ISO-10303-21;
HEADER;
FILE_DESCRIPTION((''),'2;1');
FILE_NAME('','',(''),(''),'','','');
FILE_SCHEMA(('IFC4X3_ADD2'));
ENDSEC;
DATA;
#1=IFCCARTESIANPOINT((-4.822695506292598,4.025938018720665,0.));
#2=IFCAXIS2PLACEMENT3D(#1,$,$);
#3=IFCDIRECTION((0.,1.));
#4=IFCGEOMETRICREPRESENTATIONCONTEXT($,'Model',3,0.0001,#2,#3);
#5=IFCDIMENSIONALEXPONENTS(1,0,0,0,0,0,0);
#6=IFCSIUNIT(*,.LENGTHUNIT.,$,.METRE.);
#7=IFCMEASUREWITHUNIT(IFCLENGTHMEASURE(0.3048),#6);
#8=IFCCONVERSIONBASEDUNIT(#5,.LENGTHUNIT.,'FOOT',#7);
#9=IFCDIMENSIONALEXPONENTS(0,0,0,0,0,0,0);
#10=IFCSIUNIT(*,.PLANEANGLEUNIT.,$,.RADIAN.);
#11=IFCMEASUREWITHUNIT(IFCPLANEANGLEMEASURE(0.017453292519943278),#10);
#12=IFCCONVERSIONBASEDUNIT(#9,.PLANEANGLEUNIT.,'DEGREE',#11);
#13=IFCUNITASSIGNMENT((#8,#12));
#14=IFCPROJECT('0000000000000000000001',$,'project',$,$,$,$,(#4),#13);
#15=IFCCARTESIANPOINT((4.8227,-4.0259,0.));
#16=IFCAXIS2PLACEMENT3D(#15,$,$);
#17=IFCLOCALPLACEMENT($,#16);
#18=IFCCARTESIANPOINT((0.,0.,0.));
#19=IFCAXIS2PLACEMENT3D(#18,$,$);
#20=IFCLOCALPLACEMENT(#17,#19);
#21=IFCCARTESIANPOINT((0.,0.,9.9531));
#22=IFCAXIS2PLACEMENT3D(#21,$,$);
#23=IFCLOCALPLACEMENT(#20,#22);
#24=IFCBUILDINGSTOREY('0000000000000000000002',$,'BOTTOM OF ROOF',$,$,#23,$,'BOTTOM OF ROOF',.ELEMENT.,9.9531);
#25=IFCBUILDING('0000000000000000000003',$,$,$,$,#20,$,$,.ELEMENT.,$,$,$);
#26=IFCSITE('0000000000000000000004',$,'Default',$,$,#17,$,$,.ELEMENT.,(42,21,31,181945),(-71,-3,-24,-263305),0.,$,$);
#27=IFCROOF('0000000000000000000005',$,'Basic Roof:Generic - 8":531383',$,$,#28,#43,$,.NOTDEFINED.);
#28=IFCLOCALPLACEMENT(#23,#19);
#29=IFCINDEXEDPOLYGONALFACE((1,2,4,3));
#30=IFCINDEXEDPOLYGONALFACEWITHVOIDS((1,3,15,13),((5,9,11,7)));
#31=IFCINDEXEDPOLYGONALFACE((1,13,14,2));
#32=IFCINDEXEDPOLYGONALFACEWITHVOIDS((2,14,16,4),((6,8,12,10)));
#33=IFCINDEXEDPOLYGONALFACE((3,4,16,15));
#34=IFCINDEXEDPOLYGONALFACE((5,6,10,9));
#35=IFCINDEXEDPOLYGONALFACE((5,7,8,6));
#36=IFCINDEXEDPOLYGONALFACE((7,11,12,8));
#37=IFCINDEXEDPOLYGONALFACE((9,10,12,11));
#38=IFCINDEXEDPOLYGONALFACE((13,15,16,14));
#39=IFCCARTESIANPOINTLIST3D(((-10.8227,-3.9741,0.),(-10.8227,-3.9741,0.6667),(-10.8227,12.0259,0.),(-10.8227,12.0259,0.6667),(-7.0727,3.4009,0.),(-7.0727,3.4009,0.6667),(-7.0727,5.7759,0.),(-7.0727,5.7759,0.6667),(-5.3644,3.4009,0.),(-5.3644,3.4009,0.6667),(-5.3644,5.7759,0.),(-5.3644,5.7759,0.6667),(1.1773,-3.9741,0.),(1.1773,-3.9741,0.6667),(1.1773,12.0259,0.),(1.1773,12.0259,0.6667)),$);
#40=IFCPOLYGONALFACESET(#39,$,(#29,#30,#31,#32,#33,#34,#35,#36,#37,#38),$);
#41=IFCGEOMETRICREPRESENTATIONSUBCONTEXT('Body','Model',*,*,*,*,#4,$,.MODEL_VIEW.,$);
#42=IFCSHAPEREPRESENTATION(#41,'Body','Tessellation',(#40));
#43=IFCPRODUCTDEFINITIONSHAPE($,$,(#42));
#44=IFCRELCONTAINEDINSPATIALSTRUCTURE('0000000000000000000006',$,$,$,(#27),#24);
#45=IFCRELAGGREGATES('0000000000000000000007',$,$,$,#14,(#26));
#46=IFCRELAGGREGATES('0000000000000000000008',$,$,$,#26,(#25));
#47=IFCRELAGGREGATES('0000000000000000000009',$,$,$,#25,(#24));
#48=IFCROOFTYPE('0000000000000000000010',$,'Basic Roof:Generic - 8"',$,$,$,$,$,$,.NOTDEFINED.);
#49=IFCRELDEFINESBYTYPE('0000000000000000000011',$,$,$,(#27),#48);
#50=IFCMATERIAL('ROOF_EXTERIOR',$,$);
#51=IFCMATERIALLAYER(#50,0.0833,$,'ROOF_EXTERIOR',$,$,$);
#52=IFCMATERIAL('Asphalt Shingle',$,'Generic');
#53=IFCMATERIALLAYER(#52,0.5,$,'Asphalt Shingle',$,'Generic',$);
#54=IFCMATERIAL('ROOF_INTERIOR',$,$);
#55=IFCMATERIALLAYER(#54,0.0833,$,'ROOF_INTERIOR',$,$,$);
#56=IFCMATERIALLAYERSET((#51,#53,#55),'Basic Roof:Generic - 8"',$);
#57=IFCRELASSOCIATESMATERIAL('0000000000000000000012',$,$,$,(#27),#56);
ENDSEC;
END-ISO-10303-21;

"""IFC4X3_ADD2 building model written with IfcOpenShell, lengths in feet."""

from ifc_helpers import new_model, entity, si_unit, converted_unit, direction, frame, origin, origin_2d_with_axis, place, context, subcontext, project, spatial, rectangle, extrude, material, layer, layer_set, type_object, element, save


model = new_model("IFC4X3_ADD2")

# Units and contexts
model_context = context("Model", 3, precision=0.0001, world=frame((-4.822695506292598, 4.025938018720665, 0.0)), true_north=direction((0.0, 1.0)))
body_context = subcontext(model_context, "Body", "Model", "MODEL_VIEW")
ifc_project = project(units=[converted_unit("LENGTHUNIT", "FOOT", entity("IfcLengthMeasure", 0.3048), si_unit("LENGTHUNIT", "METRE"), dimensions=[1, 0, 0, 0, 0, 0, 0]), converted_unit("PLANEANGLEUNIT", "DEGREE", entity("IfcPlaneAngleMeasure", 0.017453292519943278), si_unit("PLANEANGLEUNIT", "RADIAN"), dimensions=[0, 0, 0, 0, 0, 0, 0])], contexts=[model_context])

# Site, building, storey
site_placement = place(None, frame((4.8227, -4.0259, 0.0)))
site = spatial("IfcSite", under=ifc_project, at=site_placement, Name="Default", CompositionType="ELEMENT", RefLatitude=(42, 21, 31, 181945), RefLongitude=(-71, -3, -24, -263305), RefElevation=0.0)
building_placement = place(site_placement, origin())
building = spatial("IfcBuilding", under=site, at=building_placement, CompositionType="ELEMENT")
storey_placement = place(building_placement, frame((0.0, 0.0, 9.9531)))
storey = spatial("IfcBuildingStorey", under=building, at=storey_placement, Name="BOTTOM OF ROOF", LongName="BOTTOM OF ROOF", CompositionType="ELEMENT", Elevation=9.9531)

# Roof, opening
ifc_material_1 = material(Name="ROOF_EXTERIOR")
ifc_layer_1 = layer(ifc_material_1, 0.0833, Name="ROOF_EXTERIOR")
ifc_material_2 = material(Name="Asphalt Shingle", Category="Generic")
ifc_layer_2 = layer(ifc_material_2, 0.5, Name="Asphalt Shingle", Category="Generic")
ifc_material_3 = material(Name="ROOF_INTERIOR")
ifc_layer_3 = layer(ifc_material_3, 0.0833, Name="ROOF_INTERIOR")
ifc_layer_set_1 = layer_set([ifc_layer_1, ifc_layer_2, ifc_layer_3], Name="Basic Roof:Generic - 8\"")
roof_type = type_object("IfcRoofType", Name="Basic Roof:Generic - 8\"", PredefinedType="NOTDEFINED")
roof_placement = place(storey_placement, frame((-10.8227, -3.9741, 0.0)))
roof = element("IfcRoof", 1, at=roof_placement, inside=storey, type_object=roof_type, material=ifc_layer_set_1, Name="Basic Roof:Generic - 8\":531383", PredefinedType="NOTDEFINED", context=body_context, shape_type="SweptSolid", body=[
    extrude(rectangle(XDim=16.0, YDim=12.0, at=origin_2d_with_axis()), frame((6.0, 8.0, 0.0), z_axis=(0.0, 0.0, 1.0), x_axis=(0.0, -1.0, 0.0)), (0.0, 0.0, 1.0), 0.6667),
])
opening_placement = place(storey_placement, frame((-10.8227, -3.9741, 0.0)))
element("IfcOpeningElement", 2, at=opening_placement, cuts=roof, PredefinedType="OPENING", context=body_context, shape_type="SweptSolid", body=[
    extrude(rectangle(XDim=1.7083, YDim=2.375, at=origin_2d_with_axis()), frame((4.6042, 8.5625, 0.0), z_axis=(0.0, 0.0, 1.0), x_axis=(-1.0, 0.0, 0.0)), (0.0, 0.0, 1.0), 0.6667),
])

save(model, "model.ifc")
